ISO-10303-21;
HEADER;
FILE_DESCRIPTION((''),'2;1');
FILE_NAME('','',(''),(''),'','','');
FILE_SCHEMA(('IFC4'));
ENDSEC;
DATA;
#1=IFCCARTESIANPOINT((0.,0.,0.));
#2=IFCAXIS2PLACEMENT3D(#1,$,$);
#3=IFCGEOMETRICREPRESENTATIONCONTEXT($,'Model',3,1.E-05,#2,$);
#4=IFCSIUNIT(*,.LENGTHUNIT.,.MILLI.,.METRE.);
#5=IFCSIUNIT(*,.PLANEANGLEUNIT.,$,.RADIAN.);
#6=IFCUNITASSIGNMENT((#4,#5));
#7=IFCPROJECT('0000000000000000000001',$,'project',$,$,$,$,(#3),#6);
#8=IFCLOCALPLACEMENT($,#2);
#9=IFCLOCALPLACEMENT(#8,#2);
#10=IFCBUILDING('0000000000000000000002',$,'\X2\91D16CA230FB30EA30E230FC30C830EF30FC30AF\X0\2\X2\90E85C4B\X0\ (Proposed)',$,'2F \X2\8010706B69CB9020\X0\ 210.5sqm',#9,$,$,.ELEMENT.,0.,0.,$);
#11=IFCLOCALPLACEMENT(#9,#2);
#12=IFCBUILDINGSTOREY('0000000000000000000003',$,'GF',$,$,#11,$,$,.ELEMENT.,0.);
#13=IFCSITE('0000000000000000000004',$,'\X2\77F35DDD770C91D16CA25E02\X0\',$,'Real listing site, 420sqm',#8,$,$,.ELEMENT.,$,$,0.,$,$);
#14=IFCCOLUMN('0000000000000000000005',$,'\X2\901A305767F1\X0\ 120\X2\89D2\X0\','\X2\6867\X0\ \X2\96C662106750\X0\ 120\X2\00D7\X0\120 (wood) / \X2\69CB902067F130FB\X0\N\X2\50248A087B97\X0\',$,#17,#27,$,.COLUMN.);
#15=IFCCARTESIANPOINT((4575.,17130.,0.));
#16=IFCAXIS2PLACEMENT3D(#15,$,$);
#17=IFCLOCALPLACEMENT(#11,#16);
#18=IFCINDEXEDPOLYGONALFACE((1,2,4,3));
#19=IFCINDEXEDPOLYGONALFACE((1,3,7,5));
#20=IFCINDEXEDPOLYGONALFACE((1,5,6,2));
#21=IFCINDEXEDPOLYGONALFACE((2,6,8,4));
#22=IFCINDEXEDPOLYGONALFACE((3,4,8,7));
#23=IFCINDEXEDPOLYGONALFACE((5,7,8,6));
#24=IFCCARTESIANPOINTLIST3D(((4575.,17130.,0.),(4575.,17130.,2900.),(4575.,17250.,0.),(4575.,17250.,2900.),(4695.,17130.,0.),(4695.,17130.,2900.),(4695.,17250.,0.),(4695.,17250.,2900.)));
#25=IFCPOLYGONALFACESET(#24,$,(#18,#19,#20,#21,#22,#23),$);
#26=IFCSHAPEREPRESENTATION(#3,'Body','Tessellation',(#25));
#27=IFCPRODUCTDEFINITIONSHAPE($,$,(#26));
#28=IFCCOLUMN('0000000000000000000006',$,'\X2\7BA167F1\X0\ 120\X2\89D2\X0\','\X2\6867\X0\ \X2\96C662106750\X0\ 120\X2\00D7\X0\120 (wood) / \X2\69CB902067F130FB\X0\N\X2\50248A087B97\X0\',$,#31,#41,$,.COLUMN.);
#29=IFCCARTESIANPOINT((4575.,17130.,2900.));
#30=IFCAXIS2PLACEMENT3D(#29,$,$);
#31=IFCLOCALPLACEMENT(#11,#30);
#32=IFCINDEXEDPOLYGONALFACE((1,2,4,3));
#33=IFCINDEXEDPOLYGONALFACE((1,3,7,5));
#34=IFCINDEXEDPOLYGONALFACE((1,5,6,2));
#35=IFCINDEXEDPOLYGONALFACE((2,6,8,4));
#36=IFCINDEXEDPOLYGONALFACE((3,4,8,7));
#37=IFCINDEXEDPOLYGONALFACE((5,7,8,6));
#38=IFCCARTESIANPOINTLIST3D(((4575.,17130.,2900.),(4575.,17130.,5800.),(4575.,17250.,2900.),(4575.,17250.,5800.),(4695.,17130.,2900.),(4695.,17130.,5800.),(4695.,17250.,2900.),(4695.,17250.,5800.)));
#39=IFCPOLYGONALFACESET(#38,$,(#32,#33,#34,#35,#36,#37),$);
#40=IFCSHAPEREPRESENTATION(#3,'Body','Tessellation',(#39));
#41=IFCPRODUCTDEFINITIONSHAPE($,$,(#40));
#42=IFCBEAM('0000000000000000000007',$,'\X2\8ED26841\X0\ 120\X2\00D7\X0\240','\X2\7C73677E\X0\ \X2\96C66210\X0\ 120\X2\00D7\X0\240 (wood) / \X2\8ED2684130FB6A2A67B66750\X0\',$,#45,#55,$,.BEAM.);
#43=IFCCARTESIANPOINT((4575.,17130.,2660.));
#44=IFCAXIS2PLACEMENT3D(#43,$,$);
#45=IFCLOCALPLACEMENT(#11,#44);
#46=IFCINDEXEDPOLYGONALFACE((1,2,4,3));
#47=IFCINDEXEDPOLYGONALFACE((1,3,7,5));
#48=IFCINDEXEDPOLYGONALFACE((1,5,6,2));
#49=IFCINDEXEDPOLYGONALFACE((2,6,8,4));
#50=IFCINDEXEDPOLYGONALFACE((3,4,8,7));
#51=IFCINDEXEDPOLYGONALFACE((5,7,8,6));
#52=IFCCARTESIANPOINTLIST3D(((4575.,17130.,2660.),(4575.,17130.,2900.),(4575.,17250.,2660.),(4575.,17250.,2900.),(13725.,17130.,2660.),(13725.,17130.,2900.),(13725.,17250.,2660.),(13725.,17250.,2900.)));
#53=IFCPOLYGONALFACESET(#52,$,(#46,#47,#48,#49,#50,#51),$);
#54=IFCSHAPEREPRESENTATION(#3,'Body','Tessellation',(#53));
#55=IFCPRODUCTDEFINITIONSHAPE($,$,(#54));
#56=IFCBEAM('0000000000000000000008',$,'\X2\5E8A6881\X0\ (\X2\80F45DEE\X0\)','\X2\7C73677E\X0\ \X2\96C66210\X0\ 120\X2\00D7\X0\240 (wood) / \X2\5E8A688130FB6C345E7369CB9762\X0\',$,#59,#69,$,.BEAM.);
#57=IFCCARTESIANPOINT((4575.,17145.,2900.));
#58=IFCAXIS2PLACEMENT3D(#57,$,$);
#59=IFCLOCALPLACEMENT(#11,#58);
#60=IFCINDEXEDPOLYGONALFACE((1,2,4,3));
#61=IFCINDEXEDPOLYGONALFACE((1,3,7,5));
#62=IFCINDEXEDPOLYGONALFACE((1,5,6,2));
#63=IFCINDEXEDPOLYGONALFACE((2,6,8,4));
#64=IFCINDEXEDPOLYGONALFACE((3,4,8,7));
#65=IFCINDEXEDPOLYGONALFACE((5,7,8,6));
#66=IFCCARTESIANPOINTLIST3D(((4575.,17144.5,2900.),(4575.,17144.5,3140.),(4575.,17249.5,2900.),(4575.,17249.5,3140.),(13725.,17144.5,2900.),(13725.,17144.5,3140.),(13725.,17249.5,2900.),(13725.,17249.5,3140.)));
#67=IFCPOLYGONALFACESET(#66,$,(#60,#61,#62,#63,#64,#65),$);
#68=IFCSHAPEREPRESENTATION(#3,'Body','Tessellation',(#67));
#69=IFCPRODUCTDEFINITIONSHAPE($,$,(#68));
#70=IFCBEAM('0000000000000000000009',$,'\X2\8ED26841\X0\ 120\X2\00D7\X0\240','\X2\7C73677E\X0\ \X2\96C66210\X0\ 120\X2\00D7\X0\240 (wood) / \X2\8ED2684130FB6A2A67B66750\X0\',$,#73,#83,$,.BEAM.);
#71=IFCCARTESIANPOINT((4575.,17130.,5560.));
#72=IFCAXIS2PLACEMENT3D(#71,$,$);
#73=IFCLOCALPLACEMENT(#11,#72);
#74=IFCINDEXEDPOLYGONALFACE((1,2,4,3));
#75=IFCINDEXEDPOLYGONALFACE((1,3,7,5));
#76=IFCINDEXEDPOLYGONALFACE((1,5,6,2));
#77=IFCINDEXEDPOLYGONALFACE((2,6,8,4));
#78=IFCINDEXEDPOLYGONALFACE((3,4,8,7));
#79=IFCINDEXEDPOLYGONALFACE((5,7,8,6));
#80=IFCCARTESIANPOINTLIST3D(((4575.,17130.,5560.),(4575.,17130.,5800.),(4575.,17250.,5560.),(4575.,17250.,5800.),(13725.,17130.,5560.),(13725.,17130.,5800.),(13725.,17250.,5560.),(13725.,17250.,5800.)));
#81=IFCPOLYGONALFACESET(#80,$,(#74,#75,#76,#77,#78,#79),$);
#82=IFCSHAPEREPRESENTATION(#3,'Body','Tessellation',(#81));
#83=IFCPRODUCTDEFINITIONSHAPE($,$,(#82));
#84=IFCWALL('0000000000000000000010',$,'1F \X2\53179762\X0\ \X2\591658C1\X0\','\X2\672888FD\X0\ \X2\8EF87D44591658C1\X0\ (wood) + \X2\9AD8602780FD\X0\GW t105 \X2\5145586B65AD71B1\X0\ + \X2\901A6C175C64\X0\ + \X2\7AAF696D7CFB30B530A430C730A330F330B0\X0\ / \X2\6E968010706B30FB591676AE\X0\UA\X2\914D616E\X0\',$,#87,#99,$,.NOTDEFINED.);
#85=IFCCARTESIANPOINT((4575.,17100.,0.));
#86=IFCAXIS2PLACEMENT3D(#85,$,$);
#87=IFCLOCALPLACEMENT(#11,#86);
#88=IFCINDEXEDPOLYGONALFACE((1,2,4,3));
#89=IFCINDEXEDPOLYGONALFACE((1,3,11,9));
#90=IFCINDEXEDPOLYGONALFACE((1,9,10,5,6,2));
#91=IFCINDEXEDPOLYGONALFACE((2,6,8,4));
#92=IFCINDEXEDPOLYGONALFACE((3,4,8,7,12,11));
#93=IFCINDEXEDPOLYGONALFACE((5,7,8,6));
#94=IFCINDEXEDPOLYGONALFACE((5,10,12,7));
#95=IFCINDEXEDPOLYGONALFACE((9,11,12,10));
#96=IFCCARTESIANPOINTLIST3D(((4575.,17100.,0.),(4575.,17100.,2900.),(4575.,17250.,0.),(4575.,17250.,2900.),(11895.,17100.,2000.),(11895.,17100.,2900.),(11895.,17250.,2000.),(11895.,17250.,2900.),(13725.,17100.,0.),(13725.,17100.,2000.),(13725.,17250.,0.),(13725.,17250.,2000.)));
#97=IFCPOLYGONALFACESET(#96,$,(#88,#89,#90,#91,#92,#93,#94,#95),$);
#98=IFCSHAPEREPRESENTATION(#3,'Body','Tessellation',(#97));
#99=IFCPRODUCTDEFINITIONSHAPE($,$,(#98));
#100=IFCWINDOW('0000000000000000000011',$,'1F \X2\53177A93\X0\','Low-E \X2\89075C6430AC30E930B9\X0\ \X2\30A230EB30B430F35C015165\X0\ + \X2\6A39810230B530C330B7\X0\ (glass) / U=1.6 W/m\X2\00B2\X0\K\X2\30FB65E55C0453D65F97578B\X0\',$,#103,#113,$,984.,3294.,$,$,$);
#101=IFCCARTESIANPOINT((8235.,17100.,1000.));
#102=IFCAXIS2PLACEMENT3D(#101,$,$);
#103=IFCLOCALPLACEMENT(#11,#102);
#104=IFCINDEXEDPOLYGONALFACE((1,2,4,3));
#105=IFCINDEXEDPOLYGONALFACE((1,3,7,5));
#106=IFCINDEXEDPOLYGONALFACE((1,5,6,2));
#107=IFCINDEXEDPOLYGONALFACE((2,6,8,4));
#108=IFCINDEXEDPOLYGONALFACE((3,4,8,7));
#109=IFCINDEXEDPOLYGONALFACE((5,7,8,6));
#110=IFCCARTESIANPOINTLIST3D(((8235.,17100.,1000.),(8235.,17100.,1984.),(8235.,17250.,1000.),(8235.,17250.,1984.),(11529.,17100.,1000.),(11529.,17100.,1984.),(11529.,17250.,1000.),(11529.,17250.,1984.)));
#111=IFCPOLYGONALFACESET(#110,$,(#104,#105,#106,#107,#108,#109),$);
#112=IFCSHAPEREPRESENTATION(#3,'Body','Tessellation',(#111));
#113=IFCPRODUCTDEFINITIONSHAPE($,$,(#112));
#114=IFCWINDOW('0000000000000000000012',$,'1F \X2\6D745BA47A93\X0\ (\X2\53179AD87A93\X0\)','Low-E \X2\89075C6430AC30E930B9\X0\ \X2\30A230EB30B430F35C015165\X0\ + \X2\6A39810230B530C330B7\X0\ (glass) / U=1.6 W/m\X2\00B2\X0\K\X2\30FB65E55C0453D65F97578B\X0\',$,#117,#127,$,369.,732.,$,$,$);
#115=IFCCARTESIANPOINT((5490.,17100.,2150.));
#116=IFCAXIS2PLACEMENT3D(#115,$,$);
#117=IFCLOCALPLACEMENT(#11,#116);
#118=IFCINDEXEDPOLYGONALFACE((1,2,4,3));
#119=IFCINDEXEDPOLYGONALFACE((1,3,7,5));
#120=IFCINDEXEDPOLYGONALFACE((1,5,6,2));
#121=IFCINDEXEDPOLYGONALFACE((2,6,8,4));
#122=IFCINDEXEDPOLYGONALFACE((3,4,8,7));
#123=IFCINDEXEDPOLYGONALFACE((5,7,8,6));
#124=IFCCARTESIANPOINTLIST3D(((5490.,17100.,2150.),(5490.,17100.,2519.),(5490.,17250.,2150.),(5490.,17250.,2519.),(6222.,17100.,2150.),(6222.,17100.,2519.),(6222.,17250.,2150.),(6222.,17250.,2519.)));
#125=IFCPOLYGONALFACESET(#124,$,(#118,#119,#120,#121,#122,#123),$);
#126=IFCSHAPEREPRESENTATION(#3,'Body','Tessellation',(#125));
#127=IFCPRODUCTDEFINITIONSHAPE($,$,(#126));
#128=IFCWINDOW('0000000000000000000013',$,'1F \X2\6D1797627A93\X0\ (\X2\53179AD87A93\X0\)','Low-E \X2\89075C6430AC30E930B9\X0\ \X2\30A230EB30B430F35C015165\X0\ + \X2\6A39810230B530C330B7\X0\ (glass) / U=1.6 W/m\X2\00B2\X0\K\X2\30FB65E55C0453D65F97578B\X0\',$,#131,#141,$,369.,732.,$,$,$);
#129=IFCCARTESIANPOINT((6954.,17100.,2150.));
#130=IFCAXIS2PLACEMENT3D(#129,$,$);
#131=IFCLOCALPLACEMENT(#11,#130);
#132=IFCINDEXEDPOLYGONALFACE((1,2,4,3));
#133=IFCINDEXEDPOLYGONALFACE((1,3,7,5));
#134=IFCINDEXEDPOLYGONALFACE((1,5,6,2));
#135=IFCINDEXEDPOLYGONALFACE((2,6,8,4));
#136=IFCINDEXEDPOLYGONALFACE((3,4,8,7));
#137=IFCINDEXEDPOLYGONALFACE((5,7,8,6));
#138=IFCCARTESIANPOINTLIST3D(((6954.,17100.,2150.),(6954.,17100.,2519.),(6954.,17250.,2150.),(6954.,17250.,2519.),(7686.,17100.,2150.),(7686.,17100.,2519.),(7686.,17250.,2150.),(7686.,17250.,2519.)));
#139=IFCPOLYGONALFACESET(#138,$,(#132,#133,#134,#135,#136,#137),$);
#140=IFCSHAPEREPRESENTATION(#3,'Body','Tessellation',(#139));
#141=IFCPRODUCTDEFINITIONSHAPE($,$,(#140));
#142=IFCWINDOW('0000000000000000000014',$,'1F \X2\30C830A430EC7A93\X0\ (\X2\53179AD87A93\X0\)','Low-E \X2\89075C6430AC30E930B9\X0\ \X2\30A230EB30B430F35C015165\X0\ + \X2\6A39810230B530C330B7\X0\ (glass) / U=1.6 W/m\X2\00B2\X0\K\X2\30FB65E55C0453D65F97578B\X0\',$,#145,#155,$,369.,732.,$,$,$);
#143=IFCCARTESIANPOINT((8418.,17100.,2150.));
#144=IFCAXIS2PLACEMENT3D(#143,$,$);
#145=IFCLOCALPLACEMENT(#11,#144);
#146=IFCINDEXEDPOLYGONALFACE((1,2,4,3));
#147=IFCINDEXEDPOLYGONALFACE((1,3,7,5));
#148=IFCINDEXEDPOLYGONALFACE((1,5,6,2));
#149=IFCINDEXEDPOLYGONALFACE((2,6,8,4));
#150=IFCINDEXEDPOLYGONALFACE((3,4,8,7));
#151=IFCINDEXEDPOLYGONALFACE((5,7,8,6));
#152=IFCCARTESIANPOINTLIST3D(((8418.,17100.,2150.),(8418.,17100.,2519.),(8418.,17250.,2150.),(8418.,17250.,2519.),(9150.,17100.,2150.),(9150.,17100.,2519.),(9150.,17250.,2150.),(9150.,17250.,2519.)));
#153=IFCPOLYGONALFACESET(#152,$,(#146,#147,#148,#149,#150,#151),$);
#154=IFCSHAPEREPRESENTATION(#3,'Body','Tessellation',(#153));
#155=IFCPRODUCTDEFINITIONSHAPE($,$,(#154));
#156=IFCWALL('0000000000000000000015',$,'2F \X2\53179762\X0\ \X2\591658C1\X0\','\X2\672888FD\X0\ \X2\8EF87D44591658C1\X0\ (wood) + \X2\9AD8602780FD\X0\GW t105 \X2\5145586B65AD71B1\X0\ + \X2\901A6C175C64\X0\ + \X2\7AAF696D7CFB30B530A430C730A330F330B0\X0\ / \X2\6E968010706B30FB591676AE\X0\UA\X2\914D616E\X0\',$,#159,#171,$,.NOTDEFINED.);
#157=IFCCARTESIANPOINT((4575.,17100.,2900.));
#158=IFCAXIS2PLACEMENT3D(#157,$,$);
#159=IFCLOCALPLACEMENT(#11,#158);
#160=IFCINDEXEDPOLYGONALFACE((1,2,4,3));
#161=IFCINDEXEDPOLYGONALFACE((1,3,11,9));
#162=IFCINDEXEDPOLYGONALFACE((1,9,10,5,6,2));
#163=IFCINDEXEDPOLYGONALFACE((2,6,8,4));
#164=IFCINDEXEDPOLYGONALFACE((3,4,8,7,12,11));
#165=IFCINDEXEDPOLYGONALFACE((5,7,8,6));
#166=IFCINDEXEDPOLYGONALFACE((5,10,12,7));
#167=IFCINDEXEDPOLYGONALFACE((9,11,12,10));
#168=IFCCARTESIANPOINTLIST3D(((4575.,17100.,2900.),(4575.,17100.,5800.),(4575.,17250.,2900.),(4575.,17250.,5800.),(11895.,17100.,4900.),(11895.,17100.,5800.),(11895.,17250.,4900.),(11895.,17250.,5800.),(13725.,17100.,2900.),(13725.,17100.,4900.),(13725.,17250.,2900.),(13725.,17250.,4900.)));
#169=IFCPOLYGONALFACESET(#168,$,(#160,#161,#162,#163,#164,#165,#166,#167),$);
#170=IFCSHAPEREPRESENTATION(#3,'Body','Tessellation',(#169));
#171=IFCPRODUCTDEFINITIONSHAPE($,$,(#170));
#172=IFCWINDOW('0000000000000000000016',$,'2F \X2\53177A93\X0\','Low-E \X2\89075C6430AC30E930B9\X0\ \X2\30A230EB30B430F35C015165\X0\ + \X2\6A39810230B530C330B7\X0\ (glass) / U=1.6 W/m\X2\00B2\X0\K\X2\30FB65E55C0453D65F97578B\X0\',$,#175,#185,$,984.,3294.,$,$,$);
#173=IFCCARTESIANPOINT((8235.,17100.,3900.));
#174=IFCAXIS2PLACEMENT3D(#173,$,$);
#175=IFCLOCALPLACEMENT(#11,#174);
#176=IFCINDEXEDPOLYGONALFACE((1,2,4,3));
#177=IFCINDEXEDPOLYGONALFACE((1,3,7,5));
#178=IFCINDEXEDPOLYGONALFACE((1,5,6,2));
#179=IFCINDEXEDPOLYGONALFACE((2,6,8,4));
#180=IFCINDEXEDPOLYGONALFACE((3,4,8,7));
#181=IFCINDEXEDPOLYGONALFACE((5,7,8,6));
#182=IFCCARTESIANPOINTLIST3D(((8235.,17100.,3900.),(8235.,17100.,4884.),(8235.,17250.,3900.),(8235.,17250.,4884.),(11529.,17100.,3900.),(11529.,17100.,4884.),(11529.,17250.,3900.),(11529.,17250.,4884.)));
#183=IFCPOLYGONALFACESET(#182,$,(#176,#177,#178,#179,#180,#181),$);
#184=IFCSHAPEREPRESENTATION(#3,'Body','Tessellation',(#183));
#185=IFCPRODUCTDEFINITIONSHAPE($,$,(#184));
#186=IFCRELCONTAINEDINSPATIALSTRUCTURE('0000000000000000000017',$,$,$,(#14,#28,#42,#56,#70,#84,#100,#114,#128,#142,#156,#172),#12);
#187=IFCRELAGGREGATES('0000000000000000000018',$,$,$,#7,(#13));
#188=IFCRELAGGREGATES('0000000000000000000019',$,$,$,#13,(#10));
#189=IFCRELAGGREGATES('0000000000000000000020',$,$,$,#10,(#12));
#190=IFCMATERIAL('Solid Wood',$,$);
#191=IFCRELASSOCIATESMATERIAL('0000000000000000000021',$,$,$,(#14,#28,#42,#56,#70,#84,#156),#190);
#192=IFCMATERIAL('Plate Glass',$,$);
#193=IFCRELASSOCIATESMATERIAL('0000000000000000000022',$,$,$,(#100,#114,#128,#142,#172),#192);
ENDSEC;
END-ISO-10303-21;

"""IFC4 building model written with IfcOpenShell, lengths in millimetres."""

from ifc_helpers import new_model, si_unit, frame, frame_2d, origin, place, context, project, spatial, rectangle, extrude, material, element, fill, save


model = new_model("IFC4")

# Units and contexts
model_context = context("Model", 3, precision=1e-05, world=origin())
ifc_project = project(units=[si_unit("LENGTHUNIT", "METRE", prefix="MILLI"), si_unit("PLANEANGLEUNIT", "RADIAN")], contexts=[model_context])

# Site, building, storey
site_placement = place(None, origin())
site = spatial("IfcSite", under=ifc_project, at=site_placement, Name="石川県金沢市", ObjectType="Real listing site, 420sqm", CompositionType="ELEMENT", RefElevation=0.0)
building_placement = place(site_placement, origin())
building = spatial("IfcBuilding", under=site, at=building_placement, Name="金沢・リモートワーク2部屋 (Proposed)", ObjectType="2F 耐火構造 210.5sqm", CompositionType="ELEMENT", ElevationOfRefHeight=0.0, ElevationOfTerrain=0.0)
storey_placement = place(building_placement, origin())
storey = spatial("IfcBuildingStorey", under=building, at=storey_placement, Name="GF", CompositionType="ELEMENT", Elevation=0.0)

# Columns
ifc_material_1 = material(Name="Solid Wood")
column_1_placement = place(storey_placement, frame((4575.0, 17130.0, 0.0)))
element("IfcColumn", 1, at=column_1_placement, inside=storey, material=ifc_material_1, Name="通し柱 120角", Description="桧 集成材 120×120 (wood) / 構造柱・N値計算", PredefinedType="COLUMN", context=model_context, shape_type="SweptSolid", body=[
    extrude(rectangle(XDim=120.0, YDim=120.0, at=frame_2d((60.0, 60.0))), frame((4575.0, 17130.0, 0.0)), (0.0, 0.0, 1.0), 2900.0),
])
column_2_placement = place(storey_placement, frame((4575.0, 17130.0, 2900.0)))
element("IfcColumn", 2, at=column_2_placement, inside=storey, material=ifc_material_1, Name="管柱 120角", Description="桧 集成材 120×120 (wood) / 構造柱・N値計算", PredefinedType="COLUMN", context=model_context, shape_type="SweptSolid", body=[
    extrude(rectangle(XDim=120.0, YDim=120.0, at=frame_2d((60.0, 60.0))), frame((4575.0, 17130.0, 2900.0)), (0.0, 0.0, 1.0), 2900.0),
])

# Beams
beam_1_placement = place(storey_placement, frame((4575.0, 17130.0, 2660.0)))
element("IfcBeam", 3, at=beam_1_placement, inside=storey, material=ifc_material_1, Name="軒桁 120×240", Description="米松 集成 120×240 (wood) / 軒桁・横架材", PredefinedType="BEAM", context=model_context, shape_type="SweptSolid", body=[
    extrude(rectangle(XDim=9150.0, YDim=120.0, at=frame_2d((4575.0, 60.0))), frame((4575.0, 17130.0, 2660.0)), (0.0, 0.0, 1.0), 240.0),
])
beam_2_placement = place(storey_placement, frame((4575.0, 17145.0, 2900.0)))
element("IfcBeam", 4, at=beam_2_placement, inside=storey, material=ifc_material_1, Name="床梁 (胴差)", Description="米松 集成 120×240 (wood) / 床梁・水平構面", PredefinedType="BEAM", context=model_context, shape_type="SweptSolid", body=[
    extrude(rectangle(XDim=9150.0, YDim=105.0, at=frame_2d((4575.0, 52.0))), frame((4575.0, 17145.0, 2900.0)), (0.0, 0.0, 1.0), 240.0),
])
beam_3_placement = place(storey_placement, frame((4575.0, 17130.0, 5560.0)))
element("IfcBeam", 5, at=beam_3_placement, inside=storey, material=ifc_material_1, Name="軒桁 120×240", Description="米松 集成 120×240 (wood) / 軒桁・横架材", PredefinedType="BEAM", context=model_context, shape_type="SweptSolid", body=[
    extrude(rectangle(XDim=9150.0, YDim=120.0, at=frame_2d((4575.0, 60.0))), frame((4575.0, 17130.0, 5560.0)), (0.0, 0.0, 1.0), 240.0),
])

# Wall, openings, windows
wall_1_placement = place(storey_placement, frame((4575.0, 17100.0, 0.0)))
wall_1 = element("IfcWall", 6, at=wall_1_placement, inside=storey, material=ifc_material_1, Name="1F 北面 外壁", Description="木製 軸組外壁 (wood) + 高性能GW t105 充填断熱 + 通気層 + 窯業系サイディング / 準耐火・外皮UA配慮", PredefinedType="NOTDEFINED", context=model_context, shape_type="SweptSolid", body=[
    extrude(rectangle(XDim=9150.0, YDim=150.0, at=frame_2d((4575.0, 75.0))), frame((4575.0, 17100.0, 0.0)), (0.0, 0.0, 1.0), 2900.0),
])
opening_1_placement = place(storey_placement, frame((8235.0, 17100.0, 1000.0)))
opening_1 = element("IfcOpeningElement", 7, at=opening_1_placement, cuts=wall_1, PredefinedType="NOTDEFINED", context=model_context, shape_type="SweptSolid", body=[
    extrude(rectangle(XDim=3294.0, YDim=150.0, at=frame_2d((1647.0, 75.0))), frame((8235.0, 17100.0, 1000.0)), (0.0, 0.0, 1.0), 984.0),
])
opening_2_placement = place(storey_placement, frame((5490.0, 17100.0, 2150.0)))
opening_2 = element("IfcOpeningElement", 8, at=opening_2_placement, cuts=wall_1, PredefinedType="NOTDEFINED", context=model_context, shape_type="SweptSolid", body=[
    extrude(rectangle(XDim=732.0, YDim=150.0, at=frame_2d((366.0, 75.0))), frame((5490.0, 17100.0, 2150.0)), (0.0, 0.0, 1.0), 369.0),
])
opening_3_placement = place(storey_placement, frame((6954.0, 17100.0, 2150.0)))
opening_3 = element("IfcOpeningElement", 9, at=opening_3_placement, cuts=wall_1, PredefinedType="NOTDEFINED", context=model_context, shape_type="SweptSolid", body=[
    extrude(rectangle(XDim=732.0, YDim=150.0, at=frame_2d((366.0, 75.0))), frame((6954.0, 17100.0, 2150.0)), (0.0, 0.0, 1.0), 369.0),
])
opening_4_placement = place(storey_placement, frame((8418.0, 17100.0, 2150.0)))
opening_4 = element("IfcOpeningElement", 10, at=opening_4_placement, cuts=wall_1, PredefinedType="NOTDEFINED", context=model_context, shape_type="SweptSolid", body=[
    extrude(rectangle(XDim=732.0, YDim=150.0, at=frame_2d((366.0, 75.0))), frame((8418.0, 17100.0, 2150.0)), (0.0, 0.0, 1.0), 369.0),
])
ifc_material_2 = material(Name="Plate Glass")
window_1_placement = place(storey_placement, frame((8235.0, 17100.0, 1000.0)))
window_1 = element("IfcWindow", 11, at=window_1_placement, inside=storey, material=ifc_material_2, Name="1F 北窓", Description="Low-E 複層ガラス アルゴン封入 + 樹脂サッシ (glass) / U=1.6 W/m²K・日射取得型", OverallHeight=984.0, OverallWidth=3294.0, context=model_context, shape_type="SweptSolid", body=[
    extrude(rectangle(XDim=3294.0, YDim=150.0, at=frame_2d((1647.0, 75.0))), frame((8235.0, 17100.0, 1000.0)), (0.0, 0.0, 1.0), 984.0),
])
fill(opening_1, window_1)
window_2_placement = place(storey_placement, frame((5490.0, 17100.0, 2150.0)))
window_2 = element("IfcWindow", 12, at=window_2_placement, inside=storey, material=ifc_material_2, Name="1F 浴室窓 (北高窓)", Description="Low-E 複層ガラス アルゴン封入 + 樹脂サッシ (glass) / U=1.6 W/m²K・日射取得型", OverallHeight=369.0, OverallWidth=732.0, context=model_context, shape_type="SweptSolid", body=[
    extrude(rectangle(XDim=732.0, YDim=150.0, at=frame_2d((366.0, 75.0))), frame((5490.0, 17100.0, 2150.0)), (0.0, 0.0, 1.0), 369.0),
])
fill(opening_2, window_2)
window_3_placement = place(storey_placement, frame((6954.0, 17100.0, 2150.0)))
window_3 = element("IfcWindow", 13, at=window_3_placement, inside=storey, material=ifc_material_2, Name="1F 洗面窓 (北高窓)", Description="Low-E 複層ガラス アルゴン封入 + 樹脂サッシ (glass) / U=1.6 W/m²K・日射取得型", OverallHeight=369.0, OverallWidth=732.0, context=model_context, shape_type="SweptSolid", body=[
    extrude(rectangle(XDim=732.0, YDim=150.0, at=frame_2d((366.0, 75.0))), frame((6954.0, 17100.0, 2150.0)), (0.0, 0.0, 1.0), 369.0),
])
fill(opening_3, window_3)
window_4_placement = place(storey_placement, frame((8418.0, 17100.0, 2150.0)))
window_4 = element("IfcWindow", 14, at=window_4_placement, inside=storey, material=ifc_material_2, Name="1F トイレ窓 (北高窓)", Description="Low-E 複層ガラス アルゴン封入 + 樹脂サッシ (glass) / U=1.6 W/m²K・日射取得型", OverallHeight=369.0, OverallWidth=732.0, context=model_context, shape_type="SweptSolid", body=[
    extrude(rectangle(XDim=732.0, YDim=150.0, at=frame_2d((366.0, 75.0))), frame((8418.0, 17100.0, 2150.0)), (0.0, 0.0, 1.0), 369.0),
])
fill(opening_4, window_4)

# Wall, opening, window
wall_2_placement = place(storey_placement, frame((4575.0, 17100.0, 2900.0)))
wall_2 = element("IfcWall", 15, at=wall_2_placement, inside=storey, material=ifc_material_1, Name="2F 北面 外壁", Description="木製 軸組外壁 (wood) + 高性能GW t105 充填断熱 + 通気層 + 窯業系サイディング / 準耐火・外皮UA配慮", PredefinedType="NOTDEFINED", context=model_context, shape_type="SweptSolid", body=[
    extrude(rectangle(XDim=9150.0, YDim=150.0, at=frame_2d((4575.0, 75.0))), frame((4575.0, 17100.0, 2900.0)), (0.0, 0.0, 1.0), 2900.0),
])
opening_5_placement = place(storey_placement, frame((8235.0, 17100.0, 3900.0)))
opening_5 = element("IfcOpeningElement", 16, at=opening_5_placement, cuts=wall_2, PredefinedType="NOTDEFINED", context=model_context, shape_type="SweptSolid", body=[
    extrude(rectangle(XDim=3294.0, YDim=150.0, at=frame_2d((1647.0, 75.0))), frame((8235.0, 17100.0, 3900.0)), (0.0, 0.0, 1.0), 984.0),
])
window_5_placement = place(storey_placement, frame((8235.0, 17100.0, 3900.0)))
window_5 = element("IfcWindow", 17, at=window_5_placement, inside=storey, material=ifc_material_2, Name="2F 北窓", Description="Low-E 複層ガラス アルゴン封入 + 樹脂サッシ (glass) / U=1.6 W/m²K・日射取得型", OverallHeight=984.0, OverallWidth=3294.0, context=model_context, shape_type="SweptSolid", body=[
    extrude(rectangle(XDim=3294.0, YDim=150.0, at=frame_2d((1647.0, 75.0))), frame((8235.0, 17100.0, 3900.0)), (0.0, 0.0, 1.0), 984.0),
])
fill(opening_5, window_5)

save(model, "model.ifc")
